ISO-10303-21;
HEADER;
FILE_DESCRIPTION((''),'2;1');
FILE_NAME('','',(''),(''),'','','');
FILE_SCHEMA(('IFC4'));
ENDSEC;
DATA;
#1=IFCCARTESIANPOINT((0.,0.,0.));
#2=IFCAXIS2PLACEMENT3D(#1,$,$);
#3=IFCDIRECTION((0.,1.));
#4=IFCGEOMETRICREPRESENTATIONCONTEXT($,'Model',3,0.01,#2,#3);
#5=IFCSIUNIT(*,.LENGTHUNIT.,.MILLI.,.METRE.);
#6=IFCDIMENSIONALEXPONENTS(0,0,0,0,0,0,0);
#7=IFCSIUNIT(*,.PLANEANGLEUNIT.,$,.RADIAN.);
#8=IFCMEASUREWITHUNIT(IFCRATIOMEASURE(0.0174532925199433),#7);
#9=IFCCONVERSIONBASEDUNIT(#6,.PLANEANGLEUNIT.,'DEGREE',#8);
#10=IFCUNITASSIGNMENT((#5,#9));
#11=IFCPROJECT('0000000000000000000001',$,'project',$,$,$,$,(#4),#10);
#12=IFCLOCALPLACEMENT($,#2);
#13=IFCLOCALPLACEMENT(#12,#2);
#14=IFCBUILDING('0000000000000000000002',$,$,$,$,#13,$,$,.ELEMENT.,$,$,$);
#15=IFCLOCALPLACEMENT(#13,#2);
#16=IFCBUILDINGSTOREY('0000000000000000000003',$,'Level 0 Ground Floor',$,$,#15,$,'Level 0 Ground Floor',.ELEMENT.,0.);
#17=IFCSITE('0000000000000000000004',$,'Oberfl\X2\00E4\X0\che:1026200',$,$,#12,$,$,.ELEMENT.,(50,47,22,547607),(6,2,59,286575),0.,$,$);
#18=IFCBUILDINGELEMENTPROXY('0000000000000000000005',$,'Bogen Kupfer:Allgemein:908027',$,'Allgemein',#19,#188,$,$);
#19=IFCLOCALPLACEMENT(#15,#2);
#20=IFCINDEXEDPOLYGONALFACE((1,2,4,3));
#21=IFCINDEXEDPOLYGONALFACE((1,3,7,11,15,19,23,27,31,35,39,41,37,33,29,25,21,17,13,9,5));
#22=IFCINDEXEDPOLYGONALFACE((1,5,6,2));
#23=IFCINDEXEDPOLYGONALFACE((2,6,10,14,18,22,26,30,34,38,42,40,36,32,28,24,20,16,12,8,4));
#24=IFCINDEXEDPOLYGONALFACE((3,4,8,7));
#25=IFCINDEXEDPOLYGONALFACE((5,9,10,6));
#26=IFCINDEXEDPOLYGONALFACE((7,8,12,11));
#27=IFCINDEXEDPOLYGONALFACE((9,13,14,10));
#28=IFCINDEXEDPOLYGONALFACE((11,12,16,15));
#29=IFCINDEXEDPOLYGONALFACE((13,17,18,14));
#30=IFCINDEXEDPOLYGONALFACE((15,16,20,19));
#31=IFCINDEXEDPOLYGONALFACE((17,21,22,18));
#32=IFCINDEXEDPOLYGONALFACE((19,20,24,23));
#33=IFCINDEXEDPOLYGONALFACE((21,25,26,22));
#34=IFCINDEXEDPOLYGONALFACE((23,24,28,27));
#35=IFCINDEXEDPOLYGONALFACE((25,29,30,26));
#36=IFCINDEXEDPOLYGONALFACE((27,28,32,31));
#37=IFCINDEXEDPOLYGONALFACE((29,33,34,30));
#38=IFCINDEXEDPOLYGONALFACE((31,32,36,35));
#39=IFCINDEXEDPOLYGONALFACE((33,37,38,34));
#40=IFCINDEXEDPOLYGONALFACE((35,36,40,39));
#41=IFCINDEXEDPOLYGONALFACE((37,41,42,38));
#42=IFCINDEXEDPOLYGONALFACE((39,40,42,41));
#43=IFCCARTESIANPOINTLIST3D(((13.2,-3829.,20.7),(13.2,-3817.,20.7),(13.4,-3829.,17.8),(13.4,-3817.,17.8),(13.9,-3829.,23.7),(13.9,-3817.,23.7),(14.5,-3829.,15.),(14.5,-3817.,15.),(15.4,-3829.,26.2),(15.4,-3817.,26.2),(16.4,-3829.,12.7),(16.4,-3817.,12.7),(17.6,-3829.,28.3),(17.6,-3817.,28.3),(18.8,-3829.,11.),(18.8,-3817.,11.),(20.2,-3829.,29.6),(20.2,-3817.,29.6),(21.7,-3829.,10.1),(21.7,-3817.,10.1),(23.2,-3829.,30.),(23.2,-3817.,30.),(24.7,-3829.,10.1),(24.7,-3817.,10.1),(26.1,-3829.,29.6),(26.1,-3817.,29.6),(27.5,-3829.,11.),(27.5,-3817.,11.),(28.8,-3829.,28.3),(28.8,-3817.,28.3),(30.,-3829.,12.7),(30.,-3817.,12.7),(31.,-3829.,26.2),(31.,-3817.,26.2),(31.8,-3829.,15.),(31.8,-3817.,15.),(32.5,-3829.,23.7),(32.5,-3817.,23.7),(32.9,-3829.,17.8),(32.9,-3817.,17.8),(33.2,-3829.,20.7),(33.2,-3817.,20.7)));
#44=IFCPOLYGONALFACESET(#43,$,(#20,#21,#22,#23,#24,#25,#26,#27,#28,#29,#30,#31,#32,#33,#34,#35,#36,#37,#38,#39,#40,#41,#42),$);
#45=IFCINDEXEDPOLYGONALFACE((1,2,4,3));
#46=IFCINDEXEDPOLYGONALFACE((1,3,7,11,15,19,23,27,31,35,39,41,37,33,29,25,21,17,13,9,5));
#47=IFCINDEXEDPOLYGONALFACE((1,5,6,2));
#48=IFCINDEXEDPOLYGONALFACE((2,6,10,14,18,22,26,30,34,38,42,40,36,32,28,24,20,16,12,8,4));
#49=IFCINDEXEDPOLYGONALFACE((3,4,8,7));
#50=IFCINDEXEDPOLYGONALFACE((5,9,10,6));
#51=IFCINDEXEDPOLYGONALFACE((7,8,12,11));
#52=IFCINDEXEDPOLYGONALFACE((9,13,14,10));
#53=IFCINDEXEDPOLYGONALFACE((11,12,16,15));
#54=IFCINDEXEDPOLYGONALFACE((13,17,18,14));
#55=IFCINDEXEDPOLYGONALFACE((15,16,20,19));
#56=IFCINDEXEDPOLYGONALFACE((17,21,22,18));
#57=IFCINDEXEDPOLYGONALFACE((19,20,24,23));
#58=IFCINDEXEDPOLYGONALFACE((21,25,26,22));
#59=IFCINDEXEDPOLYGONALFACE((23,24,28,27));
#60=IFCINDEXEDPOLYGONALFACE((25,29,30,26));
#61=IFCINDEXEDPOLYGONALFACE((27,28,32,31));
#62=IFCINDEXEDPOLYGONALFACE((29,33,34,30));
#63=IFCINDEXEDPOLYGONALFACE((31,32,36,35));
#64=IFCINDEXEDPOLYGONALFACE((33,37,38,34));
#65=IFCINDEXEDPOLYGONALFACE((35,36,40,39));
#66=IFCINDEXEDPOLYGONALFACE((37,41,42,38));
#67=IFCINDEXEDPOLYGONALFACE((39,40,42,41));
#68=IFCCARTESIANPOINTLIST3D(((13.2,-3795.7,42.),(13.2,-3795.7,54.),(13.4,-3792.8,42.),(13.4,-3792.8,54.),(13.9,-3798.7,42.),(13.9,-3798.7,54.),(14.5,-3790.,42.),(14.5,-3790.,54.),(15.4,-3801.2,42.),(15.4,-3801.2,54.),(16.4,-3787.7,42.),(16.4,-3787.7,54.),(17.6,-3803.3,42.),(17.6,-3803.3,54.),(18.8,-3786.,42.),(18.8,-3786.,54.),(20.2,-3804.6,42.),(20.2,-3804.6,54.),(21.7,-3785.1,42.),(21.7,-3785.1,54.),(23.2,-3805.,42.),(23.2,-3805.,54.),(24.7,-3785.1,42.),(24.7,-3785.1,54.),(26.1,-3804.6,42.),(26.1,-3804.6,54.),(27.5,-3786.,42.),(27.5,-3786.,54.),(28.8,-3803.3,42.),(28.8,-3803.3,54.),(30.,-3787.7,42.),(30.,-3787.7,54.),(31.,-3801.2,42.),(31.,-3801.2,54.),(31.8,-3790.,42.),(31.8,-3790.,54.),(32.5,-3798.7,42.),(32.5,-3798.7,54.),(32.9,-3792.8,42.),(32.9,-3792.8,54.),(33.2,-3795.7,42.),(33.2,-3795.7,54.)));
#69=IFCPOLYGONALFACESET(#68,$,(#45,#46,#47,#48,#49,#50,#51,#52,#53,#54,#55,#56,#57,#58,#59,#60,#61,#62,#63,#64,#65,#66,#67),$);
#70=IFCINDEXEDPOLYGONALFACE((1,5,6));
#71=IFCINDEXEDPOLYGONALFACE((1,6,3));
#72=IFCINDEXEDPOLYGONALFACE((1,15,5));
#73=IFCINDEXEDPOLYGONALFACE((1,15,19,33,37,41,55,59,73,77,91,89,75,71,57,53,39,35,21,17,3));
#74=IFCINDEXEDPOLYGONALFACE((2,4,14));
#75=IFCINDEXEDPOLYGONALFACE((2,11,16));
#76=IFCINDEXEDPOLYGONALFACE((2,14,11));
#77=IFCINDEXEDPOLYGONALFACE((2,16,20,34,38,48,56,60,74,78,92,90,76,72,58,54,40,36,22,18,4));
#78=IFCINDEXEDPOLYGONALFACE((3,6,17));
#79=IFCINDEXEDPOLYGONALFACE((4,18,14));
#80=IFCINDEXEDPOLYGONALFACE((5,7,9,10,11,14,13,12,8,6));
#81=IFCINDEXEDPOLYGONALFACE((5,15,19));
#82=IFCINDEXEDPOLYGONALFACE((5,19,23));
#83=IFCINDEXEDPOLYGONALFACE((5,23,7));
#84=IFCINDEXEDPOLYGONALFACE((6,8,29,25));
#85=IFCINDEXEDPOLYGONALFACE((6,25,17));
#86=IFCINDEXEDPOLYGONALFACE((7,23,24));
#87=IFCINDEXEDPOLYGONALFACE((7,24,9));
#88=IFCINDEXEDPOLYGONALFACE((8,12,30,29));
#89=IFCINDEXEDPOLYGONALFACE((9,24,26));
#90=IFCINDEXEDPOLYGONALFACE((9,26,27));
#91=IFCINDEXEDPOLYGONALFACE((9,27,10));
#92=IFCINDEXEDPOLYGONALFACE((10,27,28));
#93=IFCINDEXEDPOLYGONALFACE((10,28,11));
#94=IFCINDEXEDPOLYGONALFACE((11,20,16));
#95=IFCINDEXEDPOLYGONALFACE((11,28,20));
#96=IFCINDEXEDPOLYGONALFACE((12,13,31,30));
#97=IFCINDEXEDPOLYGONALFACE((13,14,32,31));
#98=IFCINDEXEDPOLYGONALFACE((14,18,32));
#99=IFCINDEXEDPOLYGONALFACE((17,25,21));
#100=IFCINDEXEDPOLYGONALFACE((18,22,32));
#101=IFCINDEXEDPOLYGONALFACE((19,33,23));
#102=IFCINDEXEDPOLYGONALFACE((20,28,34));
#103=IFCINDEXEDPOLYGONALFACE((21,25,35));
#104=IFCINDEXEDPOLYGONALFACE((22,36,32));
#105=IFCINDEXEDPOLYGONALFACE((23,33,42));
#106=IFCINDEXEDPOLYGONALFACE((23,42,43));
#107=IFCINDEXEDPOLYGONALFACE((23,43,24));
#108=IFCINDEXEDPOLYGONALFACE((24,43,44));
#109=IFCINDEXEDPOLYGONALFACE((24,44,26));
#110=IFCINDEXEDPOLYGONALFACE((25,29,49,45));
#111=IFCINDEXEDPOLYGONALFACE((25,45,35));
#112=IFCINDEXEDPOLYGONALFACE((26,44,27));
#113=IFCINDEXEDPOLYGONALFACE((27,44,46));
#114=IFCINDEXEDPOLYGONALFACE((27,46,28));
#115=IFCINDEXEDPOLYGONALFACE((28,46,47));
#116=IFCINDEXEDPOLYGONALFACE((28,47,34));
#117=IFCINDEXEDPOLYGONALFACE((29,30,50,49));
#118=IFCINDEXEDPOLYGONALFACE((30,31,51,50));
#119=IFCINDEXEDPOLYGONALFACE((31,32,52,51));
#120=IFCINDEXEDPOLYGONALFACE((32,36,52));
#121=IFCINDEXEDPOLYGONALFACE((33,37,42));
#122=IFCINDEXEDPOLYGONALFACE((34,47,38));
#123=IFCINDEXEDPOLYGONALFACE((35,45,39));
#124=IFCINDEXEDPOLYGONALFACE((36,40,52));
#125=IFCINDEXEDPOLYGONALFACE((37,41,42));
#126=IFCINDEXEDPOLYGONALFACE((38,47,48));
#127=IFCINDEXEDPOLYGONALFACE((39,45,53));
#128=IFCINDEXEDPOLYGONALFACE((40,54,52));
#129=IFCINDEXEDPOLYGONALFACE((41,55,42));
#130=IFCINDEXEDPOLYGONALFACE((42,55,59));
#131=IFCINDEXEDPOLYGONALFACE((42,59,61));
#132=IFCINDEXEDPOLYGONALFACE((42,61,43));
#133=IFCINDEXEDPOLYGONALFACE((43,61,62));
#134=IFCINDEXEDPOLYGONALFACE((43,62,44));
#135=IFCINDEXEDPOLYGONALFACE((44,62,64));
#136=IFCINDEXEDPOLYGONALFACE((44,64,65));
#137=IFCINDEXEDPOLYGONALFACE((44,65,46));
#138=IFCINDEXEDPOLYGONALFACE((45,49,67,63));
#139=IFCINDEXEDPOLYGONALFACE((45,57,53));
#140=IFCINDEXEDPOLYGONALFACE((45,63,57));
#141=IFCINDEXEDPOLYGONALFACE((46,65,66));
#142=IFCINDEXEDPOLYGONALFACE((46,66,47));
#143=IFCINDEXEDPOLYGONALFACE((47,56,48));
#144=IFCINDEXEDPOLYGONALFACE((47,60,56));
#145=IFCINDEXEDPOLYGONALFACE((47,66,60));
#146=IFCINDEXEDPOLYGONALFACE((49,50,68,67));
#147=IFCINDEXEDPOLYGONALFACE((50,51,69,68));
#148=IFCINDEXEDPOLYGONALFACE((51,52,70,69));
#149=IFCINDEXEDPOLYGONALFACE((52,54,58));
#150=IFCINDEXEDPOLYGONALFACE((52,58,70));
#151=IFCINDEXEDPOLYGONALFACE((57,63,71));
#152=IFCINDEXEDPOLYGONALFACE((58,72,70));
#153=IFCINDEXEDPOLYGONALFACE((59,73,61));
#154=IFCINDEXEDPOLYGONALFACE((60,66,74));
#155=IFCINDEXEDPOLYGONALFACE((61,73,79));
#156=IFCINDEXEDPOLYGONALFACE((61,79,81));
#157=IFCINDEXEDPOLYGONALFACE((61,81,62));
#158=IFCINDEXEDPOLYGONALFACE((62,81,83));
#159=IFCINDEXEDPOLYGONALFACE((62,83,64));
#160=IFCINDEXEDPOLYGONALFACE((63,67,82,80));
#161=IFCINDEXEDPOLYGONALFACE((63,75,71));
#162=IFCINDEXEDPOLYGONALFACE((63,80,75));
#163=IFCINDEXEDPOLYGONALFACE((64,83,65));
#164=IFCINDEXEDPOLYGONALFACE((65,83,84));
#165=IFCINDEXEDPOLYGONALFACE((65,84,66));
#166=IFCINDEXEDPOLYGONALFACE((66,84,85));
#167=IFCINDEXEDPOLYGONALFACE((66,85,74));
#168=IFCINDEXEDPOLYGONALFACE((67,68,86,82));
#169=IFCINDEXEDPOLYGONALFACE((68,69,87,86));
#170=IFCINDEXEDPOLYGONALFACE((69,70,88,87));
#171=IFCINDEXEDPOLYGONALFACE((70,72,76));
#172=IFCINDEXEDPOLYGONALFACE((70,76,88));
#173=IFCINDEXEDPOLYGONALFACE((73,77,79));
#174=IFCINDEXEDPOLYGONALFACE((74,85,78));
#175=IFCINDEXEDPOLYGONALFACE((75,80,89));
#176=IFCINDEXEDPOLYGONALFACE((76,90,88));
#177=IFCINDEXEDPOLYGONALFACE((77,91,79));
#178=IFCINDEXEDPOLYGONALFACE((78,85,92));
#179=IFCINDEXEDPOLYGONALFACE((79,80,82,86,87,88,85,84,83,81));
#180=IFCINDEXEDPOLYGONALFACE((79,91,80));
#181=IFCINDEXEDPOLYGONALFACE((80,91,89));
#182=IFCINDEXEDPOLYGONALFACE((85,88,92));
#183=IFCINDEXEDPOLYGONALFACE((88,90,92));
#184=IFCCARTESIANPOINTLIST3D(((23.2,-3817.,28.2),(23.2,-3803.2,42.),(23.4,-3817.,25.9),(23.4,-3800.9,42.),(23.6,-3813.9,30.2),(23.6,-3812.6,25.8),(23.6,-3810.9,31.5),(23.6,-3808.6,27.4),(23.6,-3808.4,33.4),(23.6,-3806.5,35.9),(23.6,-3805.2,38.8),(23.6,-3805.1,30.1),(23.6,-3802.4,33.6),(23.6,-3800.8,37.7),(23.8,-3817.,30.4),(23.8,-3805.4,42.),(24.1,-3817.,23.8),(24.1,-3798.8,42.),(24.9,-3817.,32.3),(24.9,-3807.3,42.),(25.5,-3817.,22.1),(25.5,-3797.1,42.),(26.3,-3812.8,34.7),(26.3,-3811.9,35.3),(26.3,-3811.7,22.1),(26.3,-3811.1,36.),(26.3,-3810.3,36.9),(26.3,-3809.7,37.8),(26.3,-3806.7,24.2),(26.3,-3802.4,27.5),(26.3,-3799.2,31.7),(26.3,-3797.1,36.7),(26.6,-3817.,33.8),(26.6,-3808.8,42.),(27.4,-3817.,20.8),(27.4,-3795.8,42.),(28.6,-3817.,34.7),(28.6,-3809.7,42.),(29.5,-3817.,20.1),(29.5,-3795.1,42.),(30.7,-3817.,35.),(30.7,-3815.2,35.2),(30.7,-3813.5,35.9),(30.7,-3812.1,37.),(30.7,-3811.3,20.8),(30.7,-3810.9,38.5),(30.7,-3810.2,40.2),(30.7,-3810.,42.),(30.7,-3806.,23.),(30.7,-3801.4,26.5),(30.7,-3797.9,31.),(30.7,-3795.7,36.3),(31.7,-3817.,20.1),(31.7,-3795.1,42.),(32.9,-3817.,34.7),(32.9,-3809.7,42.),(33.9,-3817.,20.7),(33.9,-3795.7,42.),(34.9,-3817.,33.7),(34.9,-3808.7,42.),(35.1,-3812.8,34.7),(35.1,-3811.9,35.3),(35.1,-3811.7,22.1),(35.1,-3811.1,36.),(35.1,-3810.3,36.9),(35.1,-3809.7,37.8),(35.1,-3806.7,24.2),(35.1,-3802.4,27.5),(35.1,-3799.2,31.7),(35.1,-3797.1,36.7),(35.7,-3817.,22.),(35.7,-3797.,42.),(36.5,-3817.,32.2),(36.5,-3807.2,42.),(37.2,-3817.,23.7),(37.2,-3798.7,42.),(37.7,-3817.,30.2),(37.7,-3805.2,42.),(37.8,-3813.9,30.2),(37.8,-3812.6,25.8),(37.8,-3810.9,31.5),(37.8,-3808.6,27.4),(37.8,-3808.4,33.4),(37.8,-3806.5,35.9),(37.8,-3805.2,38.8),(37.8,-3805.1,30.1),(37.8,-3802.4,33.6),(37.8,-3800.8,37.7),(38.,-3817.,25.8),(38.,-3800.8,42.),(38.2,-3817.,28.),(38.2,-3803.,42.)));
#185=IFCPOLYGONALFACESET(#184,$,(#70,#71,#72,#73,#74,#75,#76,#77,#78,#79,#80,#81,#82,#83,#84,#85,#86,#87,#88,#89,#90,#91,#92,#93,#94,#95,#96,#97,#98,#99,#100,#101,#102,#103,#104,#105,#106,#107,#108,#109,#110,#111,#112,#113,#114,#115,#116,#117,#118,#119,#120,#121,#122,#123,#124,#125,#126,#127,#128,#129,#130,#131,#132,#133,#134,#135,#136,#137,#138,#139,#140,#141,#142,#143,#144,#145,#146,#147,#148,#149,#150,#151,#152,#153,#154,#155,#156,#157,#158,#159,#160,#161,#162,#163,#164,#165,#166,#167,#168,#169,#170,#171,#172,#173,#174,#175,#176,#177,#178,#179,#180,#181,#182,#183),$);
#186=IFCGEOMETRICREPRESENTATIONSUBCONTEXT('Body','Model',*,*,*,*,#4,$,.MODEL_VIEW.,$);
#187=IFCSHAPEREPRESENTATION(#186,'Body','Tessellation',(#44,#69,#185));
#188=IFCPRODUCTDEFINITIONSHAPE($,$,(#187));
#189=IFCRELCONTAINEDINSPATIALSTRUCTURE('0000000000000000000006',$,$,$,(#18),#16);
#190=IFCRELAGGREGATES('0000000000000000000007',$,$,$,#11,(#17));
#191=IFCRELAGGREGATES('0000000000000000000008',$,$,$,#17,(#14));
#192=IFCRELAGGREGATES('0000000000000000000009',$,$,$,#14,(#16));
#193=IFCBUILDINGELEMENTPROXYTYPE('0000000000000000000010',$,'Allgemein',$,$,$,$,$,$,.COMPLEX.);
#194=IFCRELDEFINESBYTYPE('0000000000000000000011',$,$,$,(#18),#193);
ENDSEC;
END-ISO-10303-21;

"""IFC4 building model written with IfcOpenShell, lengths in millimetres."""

from ifc_helpers import new_model, entity, si_unit, converted_unit, direction, frame, frame_2d, origin, place, context, subcontext, project, spatial, circle, extrude, source, transform, mapped, type_object, type_shapes, element, save


model = new_model("IFC4")

# Units and contexts
model_context = context("Model", 3, precision=0.01, world=origin(), true_north=direction((0.0, 1.0)))
body_context = subcontext(model_context, "Body", "Model", "MODEL_VIEW")
ifc_project = project(units=[si_unit("LENGTHUNIT", "METRE", prefix="MILLI"), converted_unit("PLANEANGLEUNIT", "DEGREE", entity("IfcRatioMeasure", 0.0174532925199433), si_unit("PLANEANGLEUNIT", "RADIAN"), dimensions=[0, 0, 0, 0, 0, 0, 0])], contexts=[model_context])

# Site, building, storey
site_placement = place(None, origin())
site = spatial("IfcSite", under=ifc_project, at=site_placement, Name="Oberfläche:1026200", CompositionType="ELEMENT", RefLatitude=(50, 47, 22, 547607), RefLongitude=(6, 2, 59, 286575), RefElevation=0.0)
building_placement = place(site_placement, origin())
building = spatial("IfcBuilding", under=site, at=building_placement, CompositionType="ELEMENT")
storey_placement = place(building_placement, origin())
storey = spatial("IfcBuildingStorey", under=building, at=storey_placement, Name="Level 0 Ground Floor", LongName="Level 0 Ground Floor", CompositionType="ELEMENT", Elevation=0.0)

# Building element proxy
building_element_proxy_type = type_object("IfcBuildingElementProxyType", Name="Allgemein", PredefinedType="COMPLEX")
ifc_direction = entity("IfcDirection", [0.0, 0.0, -1.0])
trimmed_curve = entity("IfcTrimmedCurve", entity("IfcCircle", entity("IfcAxis2Placement2D", entity("IfcCartesianPoint", [-14.5, 0.0]), entity("IfcDirection", [0.0, 1.0])), 14.5), [entity("IfcParameterValue", 270.0)], [entity("IfcParameterValue", 0.0)], True, "PARAMETER")
shared_shape_1 = source(origin(), body_context, "Body", "SolidModel", [
    extrude(circle(Radius=10.0, at=frame_2d((0.0, 0.0), x_axis=(1.0, 0.0))), frame((0.0, 22.0, 0.0), z_axis=(0.0, 1.0, 0.0), x_axis=(-1.0, 0.0, 0.0)), (0.0, 0.0, 1.0), 12.0),
    extrude(circle(Radius=10.0, at=frame_2d((0.0, 0.0), x_axis=(1.0, 0.0))), frame((-34.0, 0.0, 0.0), z_axis=(1.0, 0.0, 0.0), x_axis=(0.0, 1.0, 0.0)), (0.0, 0.0, 1.0), 12.0),
    entity("IfcSurfaceCurveSweptAreaSolid", entity("IfcCircleProfileDef", "AREA", None, entity("IfcAxis2Placement2D", entity("IfcCartesianPoint", [0.0, 7.5]), entity("IfcDirection", [1.0, 0.0])), 7.5), entity("IfcAxis2Placement3D", entity("IfcCartesianPoint", [-7.5, 22.0, 0.0]), ifc_direction, entity("IfcDirection", [1.0, 0.0, 0.0])), trimmed_curve, 0.0, 90.0, entity("IfcSurfaceOfLinearExtrusion", entity("IfcArbitraryOpenProfileDef", "CURVE", None, trimmed_curve), entity("IfcAxis2Placement3D", entity("IfcCartesianPoint", [0.0, 0.0, -304.8])), ifc_direction, 1.0)),
])
type_shapes(building_element_proxy_type, [shared_shape_1])
proxy_1_placement = place(storey_placement, frame((23.2, -3795.0, 20.0), z_axis=(-1.0, 0.0, 0.0), x_axis=(0.0, 0.0, -1.0)))
element("IfcBuildingElementProxy", 1, at=proxy_1_placement, inside=storey, type_object=building_element_proxy_type, Name="Bogen Kupfer:Allgemein:908027", ObjectType="Allgemein", context=body_context, shape_type="MappedRepresentation", body=[
    mapped(shared_shape_1, transform((0.0, 0.0, 0.0), scale=1.0)),
])

save(model, "model.ifc")
